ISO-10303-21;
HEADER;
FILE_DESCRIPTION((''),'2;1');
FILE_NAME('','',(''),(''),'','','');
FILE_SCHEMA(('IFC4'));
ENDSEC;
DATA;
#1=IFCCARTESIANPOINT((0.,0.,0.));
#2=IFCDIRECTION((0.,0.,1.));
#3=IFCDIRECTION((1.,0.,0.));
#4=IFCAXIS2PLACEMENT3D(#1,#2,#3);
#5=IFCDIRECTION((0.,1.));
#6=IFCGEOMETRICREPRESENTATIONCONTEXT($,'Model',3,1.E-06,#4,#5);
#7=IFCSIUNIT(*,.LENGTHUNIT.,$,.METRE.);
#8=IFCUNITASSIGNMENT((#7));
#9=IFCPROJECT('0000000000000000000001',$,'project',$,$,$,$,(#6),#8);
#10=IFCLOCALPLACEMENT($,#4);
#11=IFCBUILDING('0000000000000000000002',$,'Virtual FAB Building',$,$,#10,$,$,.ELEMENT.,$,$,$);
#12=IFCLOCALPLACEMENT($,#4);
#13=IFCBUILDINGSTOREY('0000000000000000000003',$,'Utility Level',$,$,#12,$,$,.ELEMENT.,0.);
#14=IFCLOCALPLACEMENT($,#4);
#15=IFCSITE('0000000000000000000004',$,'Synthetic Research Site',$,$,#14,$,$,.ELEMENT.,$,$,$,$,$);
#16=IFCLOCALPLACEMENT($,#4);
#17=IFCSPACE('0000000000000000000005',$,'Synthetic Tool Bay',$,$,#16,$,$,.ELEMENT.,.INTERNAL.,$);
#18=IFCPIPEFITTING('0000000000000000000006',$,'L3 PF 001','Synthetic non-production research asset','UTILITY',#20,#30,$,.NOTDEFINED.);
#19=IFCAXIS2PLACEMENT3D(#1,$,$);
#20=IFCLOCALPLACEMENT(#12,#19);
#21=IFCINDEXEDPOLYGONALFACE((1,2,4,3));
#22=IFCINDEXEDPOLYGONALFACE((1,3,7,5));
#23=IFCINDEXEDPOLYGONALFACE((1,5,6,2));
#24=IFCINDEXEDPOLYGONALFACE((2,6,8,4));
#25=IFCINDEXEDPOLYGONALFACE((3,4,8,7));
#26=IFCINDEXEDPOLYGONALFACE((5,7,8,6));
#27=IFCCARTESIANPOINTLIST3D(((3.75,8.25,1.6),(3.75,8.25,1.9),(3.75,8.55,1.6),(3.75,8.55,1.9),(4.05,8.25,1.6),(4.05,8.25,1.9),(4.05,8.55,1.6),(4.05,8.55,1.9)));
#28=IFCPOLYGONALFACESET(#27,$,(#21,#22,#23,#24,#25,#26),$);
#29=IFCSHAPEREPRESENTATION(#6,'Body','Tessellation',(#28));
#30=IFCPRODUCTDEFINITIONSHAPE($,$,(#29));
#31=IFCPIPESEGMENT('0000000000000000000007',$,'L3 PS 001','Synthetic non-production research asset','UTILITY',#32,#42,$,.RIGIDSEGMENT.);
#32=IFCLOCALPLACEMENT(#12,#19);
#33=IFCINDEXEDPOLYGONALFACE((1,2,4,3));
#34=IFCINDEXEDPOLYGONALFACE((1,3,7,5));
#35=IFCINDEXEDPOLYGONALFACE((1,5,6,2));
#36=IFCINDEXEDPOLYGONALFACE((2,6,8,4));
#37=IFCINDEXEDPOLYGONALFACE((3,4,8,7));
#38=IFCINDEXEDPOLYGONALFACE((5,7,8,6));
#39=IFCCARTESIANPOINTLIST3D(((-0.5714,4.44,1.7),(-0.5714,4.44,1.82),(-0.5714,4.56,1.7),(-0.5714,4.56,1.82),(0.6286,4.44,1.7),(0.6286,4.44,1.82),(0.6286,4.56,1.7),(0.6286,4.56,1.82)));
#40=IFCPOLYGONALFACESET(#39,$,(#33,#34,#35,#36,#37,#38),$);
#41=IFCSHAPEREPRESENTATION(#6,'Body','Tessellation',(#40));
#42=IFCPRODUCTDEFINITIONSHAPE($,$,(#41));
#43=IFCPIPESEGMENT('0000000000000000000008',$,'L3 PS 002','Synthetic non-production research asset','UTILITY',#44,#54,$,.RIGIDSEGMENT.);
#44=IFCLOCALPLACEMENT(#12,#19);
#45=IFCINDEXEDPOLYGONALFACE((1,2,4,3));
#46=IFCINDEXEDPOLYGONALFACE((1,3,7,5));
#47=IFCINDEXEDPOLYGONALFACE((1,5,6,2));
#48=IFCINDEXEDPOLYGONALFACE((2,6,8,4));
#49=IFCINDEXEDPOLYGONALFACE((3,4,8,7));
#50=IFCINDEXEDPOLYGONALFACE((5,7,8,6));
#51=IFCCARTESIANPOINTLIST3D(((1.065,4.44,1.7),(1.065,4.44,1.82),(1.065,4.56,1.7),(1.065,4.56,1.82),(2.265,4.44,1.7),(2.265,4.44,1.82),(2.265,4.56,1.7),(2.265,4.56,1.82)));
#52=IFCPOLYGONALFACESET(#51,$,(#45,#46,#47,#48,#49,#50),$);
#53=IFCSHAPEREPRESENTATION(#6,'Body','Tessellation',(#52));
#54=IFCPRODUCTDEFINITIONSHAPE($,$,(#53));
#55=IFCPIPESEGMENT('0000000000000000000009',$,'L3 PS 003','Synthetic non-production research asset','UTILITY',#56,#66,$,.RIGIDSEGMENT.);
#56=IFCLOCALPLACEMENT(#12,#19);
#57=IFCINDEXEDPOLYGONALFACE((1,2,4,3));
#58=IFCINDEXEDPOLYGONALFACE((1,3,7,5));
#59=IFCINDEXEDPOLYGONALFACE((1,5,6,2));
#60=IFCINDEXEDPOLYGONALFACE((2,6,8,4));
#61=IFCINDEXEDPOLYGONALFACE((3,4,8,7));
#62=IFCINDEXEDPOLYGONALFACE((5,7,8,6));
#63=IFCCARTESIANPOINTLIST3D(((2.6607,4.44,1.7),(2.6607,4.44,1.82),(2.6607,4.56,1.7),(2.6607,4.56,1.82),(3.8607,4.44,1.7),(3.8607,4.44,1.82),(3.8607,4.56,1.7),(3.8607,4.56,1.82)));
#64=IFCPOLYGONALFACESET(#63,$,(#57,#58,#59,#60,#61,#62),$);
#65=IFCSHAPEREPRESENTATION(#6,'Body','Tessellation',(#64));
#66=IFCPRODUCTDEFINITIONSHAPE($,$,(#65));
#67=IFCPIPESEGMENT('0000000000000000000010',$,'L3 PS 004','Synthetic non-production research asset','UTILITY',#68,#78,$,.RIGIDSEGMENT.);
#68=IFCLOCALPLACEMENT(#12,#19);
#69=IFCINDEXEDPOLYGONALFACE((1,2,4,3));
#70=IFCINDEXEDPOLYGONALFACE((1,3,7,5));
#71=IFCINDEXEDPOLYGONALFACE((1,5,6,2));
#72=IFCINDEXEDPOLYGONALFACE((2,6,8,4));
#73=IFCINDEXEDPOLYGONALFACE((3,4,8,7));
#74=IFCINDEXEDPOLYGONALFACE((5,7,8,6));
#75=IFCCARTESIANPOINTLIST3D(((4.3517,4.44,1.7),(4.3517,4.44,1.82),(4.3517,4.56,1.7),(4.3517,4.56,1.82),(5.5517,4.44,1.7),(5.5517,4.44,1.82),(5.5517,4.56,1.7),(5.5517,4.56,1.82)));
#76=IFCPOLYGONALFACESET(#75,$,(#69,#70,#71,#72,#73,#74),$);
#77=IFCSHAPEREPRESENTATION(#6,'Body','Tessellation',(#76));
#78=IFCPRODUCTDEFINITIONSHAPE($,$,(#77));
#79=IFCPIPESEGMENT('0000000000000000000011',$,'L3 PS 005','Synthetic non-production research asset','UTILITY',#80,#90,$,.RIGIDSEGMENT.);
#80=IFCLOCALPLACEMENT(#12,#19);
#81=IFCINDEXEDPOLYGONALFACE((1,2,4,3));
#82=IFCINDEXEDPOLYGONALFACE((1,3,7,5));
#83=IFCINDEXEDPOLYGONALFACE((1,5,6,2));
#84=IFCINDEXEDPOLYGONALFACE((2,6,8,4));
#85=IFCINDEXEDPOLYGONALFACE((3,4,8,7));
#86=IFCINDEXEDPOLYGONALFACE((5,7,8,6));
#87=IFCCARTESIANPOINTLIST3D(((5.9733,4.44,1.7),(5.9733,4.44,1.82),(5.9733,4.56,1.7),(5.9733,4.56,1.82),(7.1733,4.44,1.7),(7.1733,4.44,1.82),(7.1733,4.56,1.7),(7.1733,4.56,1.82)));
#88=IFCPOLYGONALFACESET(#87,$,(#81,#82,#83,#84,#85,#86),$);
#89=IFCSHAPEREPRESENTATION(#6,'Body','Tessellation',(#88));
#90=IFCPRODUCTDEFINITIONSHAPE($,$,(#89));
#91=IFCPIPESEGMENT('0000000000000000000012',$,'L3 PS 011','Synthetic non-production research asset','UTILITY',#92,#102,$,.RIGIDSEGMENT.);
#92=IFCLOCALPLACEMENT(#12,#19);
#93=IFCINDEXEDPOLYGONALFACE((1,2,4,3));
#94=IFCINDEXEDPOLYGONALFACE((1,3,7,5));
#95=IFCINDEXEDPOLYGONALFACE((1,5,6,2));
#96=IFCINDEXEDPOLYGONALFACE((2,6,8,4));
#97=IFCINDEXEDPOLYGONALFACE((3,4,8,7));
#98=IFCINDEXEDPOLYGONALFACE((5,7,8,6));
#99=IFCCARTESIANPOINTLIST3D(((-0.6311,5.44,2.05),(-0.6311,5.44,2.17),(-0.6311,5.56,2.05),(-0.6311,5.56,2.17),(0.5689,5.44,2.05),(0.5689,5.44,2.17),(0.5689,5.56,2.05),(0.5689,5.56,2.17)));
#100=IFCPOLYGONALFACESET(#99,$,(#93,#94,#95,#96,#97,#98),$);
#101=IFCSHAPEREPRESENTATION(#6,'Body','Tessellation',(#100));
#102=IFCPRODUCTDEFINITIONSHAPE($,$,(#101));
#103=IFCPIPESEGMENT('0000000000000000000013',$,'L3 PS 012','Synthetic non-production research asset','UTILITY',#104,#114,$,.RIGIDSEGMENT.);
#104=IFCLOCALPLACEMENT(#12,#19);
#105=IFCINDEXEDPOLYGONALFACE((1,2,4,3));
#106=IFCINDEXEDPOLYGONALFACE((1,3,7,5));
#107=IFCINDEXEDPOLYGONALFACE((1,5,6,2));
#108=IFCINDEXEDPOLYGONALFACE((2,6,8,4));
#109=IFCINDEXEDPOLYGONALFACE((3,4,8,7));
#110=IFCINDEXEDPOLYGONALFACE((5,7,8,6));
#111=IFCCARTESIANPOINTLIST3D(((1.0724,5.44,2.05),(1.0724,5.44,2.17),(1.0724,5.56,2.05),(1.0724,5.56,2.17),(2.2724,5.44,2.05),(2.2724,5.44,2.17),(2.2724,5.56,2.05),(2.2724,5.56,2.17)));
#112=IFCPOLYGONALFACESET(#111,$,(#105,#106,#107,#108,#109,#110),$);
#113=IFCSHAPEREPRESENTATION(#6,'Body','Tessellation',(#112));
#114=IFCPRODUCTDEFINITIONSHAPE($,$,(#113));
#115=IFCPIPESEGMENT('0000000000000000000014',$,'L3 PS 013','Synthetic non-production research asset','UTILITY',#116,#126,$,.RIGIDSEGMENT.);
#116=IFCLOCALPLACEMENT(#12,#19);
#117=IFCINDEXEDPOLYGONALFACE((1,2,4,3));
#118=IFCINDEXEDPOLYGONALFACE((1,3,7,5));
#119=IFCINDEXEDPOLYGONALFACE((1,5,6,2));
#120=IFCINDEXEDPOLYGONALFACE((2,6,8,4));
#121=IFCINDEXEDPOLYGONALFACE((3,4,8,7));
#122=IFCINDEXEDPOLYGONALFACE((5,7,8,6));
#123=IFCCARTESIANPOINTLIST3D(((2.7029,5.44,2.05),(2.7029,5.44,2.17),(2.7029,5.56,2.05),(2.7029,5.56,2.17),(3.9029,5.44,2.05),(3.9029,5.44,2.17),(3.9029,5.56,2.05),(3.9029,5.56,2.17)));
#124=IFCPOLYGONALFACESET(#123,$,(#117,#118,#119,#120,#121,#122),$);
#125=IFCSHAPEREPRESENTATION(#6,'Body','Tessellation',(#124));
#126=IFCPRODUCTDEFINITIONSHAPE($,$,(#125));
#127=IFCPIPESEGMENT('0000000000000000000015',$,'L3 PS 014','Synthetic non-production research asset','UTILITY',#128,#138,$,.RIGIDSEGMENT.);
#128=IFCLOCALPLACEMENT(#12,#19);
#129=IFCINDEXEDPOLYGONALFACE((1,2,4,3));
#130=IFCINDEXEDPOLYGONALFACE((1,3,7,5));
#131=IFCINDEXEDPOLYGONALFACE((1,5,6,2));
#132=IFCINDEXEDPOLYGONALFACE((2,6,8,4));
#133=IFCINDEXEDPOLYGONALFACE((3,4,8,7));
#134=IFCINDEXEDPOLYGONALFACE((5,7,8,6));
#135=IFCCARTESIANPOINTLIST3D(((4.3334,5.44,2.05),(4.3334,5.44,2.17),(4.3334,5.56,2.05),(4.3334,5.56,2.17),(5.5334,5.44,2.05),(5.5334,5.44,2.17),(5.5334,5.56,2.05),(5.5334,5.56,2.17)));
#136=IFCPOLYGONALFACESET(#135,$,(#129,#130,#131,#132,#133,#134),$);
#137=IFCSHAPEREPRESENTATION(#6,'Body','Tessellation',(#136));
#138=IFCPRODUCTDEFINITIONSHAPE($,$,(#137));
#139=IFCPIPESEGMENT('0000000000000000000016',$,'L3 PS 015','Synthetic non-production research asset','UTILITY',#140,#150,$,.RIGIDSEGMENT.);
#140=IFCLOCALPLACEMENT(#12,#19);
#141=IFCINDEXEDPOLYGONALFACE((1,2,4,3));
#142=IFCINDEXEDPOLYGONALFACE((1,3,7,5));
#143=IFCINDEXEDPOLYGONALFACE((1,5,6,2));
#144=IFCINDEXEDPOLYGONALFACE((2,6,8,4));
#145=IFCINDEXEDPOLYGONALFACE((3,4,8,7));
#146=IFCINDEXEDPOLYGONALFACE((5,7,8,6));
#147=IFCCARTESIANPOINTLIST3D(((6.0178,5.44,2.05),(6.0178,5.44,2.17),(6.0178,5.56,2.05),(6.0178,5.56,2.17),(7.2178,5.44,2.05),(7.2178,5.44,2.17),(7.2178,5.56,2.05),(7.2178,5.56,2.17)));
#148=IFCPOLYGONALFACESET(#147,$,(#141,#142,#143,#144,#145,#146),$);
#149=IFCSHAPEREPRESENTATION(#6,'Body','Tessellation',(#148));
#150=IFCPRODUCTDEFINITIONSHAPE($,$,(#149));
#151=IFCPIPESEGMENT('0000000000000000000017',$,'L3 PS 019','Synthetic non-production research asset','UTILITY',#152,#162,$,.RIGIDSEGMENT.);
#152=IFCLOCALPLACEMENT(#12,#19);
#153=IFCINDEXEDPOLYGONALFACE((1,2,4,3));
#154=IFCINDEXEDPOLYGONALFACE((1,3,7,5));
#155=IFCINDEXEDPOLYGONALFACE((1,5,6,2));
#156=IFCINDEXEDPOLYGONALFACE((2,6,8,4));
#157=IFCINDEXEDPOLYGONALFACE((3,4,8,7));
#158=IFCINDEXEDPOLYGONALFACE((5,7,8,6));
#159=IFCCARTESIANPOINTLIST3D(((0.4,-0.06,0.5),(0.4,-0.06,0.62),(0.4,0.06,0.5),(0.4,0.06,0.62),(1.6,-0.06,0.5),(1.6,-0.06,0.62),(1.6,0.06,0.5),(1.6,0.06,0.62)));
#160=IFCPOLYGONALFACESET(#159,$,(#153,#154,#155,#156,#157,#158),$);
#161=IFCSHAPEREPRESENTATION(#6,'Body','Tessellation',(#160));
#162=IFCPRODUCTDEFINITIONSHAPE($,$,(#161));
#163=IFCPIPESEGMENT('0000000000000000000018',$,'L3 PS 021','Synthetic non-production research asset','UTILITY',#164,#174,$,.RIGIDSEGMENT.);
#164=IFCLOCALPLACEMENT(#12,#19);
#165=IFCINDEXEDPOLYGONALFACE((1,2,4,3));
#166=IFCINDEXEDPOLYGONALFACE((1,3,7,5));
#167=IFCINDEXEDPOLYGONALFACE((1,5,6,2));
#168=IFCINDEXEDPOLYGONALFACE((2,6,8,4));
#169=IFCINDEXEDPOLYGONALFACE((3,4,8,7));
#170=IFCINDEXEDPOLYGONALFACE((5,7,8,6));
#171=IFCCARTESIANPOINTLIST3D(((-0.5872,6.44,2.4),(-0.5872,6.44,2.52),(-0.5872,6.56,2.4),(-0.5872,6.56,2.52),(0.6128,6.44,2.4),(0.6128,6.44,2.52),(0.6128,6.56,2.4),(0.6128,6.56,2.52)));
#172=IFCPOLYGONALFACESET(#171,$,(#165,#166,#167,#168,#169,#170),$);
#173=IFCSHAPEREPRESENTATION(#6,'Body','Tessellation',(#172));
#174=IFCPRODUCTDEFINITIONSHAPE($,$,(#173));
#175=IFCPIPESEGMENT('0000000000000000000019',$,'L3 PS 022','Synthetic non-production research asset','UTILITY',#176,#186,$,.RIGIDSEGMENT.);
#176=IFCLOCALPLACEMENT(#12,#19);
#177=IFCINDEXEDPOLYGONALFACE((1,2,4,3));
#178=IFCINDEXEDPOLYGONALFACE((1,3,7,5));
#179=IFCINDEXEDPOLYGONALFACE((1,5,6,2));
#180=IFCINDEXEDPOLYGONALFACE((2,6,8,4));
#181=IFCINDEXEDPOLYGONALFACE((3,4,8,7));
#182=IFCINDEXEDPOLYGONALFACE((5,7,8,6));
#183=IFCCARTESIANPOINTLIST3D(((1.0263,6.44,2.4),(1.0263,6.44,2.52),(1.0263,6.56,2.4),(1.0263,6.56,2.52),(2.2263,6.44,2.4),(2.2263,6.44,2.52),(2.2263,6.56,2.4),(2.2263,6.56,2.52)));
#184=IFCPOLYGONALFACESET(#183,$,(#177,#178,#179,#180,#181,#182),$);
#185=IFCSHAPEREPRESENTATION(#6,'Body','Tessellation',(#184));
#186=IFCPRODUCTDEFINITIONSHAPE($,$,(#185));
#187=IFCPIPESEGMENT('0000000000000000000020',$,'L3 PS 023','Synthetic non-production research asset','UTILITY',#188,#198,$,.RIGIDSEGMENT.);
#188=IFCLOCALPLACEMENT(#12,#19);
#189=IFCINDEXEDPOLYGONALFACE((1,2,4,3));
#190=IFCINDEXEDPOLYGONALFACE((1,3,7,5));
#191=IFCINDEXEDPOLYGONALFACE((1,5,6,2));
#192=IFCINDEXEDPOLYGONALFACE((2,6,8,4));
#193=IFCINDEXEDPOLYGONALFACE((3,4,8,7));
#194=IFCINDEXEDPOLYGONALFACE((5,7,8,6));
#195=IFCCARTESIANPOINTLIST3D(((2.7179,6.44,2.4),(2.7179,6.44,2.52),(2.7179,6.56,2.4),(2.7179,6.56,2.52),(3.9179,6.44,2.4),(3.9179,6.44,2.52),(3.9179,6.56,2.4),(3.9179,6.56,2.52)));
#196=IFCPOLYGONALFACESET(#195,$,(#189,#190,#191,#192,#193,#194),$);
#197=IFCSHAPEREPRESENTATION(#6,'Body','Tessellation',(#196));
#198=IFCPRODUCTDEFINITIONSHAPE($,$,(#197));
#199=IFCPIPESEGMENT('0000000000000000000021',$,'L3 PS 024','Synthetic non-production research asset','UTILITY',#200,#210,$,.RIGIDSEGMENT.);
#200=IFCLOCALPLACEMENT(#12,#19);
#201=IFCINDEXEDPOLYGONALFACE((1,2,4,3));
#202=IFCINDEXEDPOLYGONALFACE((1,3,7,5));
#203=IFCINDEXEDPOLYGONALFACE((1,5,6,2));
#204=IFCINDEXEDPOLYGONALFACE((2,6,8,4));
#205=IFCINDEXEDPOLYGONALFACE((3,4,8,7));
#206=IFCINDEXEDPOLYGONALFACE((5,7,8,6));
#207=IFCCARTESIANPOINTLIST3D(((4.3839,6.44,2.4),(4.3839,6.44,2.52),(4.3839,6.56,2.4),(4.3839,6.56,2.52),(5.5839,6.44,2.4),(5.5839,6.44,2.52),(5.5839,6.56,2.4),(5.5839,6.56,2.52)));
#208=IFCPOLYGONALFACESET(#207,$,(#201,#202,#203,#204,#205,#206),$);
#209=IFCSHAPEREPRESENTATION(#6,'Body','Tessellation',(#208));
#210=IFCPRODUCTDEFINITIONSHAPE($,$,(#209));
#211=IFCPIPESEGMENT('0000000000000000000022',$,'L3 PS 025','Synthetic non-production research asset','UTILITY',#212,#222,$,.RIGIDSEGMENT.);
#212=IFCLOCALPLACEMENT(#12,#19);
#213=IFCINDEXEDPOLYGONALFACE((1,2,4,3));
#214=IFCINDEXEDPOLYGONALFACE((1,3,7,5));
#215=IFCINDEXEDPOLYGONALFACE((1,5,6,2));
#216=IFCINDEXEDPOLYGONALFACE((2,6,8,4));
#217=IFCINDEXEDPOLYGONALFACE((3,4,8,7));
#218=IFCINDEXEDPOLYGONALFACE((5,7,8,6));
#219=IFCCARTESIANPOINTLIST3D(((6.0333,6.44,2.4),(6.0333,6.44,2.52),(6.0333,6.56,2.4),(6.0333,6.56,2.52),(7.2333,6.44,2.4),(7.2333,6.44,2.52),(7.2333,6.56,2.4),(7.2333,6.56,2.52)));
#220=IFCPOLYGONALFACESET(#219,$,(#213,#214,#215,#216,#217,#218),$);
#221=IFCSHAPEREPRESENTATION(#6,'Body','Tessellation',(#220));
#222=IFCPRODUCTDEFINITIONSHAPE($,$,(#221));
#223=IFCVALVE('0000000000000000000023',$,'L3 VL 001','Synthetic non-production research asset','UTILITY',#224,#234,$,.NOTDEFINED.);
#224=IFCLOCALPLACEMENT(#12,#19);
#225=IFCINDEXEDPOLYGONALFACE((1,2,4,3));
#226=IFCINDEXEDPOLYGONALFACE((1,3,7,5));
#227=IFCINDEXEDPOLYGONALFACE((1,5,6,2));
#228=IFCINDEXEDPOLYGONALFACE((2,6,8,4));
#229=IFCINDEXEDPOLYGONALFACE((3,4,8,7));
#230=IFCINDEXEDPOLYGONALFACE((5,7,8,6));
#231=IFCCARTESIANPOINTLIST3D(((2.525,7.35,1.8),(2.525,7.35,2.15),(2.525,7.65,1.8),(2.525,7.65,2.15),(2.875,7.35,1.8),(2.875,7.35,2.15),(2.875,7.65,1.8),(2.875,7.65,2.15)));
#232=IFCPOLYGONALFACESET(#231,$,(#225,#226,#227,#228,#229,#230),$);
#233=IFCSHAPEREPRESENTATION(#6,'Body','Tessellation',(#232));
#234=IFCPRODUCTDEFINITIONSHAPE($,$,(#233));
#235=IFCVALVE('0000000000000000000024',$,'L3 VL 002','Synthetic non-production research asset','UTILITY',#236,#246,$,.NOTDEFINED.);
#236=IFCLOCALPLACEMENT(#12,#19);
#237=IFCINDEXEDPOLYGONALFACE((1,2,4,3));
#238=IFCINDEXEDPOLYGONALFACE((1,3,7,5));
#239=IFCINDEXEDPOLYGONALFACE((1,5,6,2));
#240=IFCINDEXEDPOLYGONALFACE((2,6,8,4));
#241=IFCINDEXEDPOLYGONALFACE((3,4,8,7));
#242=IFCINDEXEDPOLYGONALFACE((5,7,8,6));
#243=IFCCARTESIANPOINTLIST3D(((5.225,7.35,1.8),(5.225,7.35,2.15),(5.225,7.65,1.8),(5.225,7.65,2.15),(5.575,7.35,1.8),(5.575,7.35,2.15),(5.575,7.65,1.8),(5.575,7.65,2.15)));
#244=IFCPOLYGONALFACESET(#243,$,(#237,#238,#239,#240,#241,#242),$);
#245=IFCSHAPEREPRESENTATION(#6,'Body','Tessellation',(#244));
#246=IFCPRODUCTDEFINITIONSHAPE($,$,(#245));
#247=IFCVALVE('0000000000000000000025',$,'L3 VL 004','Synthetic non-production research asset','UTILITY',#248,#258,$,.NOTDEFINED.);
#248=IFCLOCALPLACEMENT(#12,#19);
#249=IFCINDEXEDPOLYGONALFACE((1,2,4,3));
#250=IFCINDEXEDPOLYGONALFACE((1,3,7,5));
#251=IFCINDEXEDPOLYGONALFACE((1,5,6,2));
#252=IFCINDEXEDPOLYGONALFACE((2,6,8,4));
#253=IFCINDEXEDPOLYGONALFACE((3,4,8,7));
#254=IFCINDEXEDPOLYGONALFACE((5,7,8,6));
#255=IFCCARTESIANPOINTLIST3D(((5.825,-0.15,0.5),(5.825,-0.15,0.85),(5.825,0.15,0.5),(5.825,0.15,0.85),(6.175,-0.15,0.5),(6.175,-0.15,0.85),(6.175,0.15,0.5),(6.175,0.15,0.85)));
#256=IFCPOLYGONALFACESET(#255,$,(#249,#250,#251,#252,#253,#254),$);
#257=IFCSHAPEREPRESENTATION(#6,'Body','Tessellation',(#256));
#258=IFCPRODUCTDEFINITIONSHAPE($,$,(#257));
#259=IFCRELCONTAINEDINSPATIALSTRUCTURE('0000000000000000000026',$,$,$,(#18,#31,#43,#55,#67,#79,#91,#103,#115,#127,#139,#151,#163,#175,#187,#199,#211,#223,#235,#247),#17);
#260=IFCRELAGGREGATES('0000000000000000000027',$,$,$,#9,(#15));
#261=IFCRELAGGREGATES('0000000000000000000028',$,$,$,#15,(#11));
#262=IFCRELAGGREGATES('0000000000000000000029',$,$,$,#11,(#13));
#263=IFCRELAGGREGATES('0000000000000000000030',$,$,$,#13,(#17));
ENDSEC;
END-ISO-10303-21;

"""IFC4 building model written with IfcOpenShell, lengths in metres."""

from ifc_helpers import new_model, si_unit, direction, frame, origin_with_axes, origin_2d_with_axis, place, context, project, spatial, rectangle, extrude, element, save


model = new_model("IFC4")

# Units and contexts
model_context = context("Model", 3, precision=1e-06, world=origin_with_axes(), true_north=direction((0.0, 1.0)))
ifc_project = project(units=[si_unit("LENGTHUNIT", "METRE")], contexts=[model_context])

# Site, building, storey, space
site_placement = place(None, origin_with_axes())
site = spatial("IfcSite", under=ifc_project, at=site_placement, Name="Synthetic Research Site", CompositionType="ELEMENT")
building_placement = place(None, origin_with_axes())
building = spatial("IfcBuilding", under=site, at=building_placement, Name="Virtual FAB Building", CompositionType="ELEMENT")
storey_placement = place(None, origin_with_axes())
storey = spatial("IfcBuildingStorey", under=building, at=storey_placement, Name="Utility Level", CompositionType="ELEMENT", Elevation=0.0)
space_placement = place(None, origin_with_axes())
space = spatial("IfcSpace", under=storey, at=space_placement, Name="Synthetic Tool Bay", CompositionType="ELEMENT", PredefinedType="INTERNAL")

# Pipe fitting
pipe_fitting_placement = place(None, frame((3.9, 8.4, 1.6), z_axis=(0.0, 0.0, 1.0), x_axis=(1.0, 0.0, 0.0)))
element("IfcPipeFitting", 1, at=pipe_fitting_placement, inside=space, Name="L3 PF 001", Description="Synthetic non-production research asset", ObjectType="UTILITY", PredefinedType="NOTDEFINED", context=model_context, shape_type="SweptSolid", body=[
    extrude(rectangle(XDim=0.3, YDim=0.3, at=origin_2d_with_axis()), origin_with_axes(), (0.0, 0.0, 1.0), 0.3),
])

# Pipe segments
for number, where, z_axis, x_axis, name in (
    (2, (0.0286, 4.5, 1.7), (0.0, 0.0, 1.0), (1.0, 0.0, 0.0), "L3 PS 001"),
    (3, (1.665, 4.5, 1.7), (0.0, 0.0, 1.0), (1.0, 0.0, 0.0), "L3 PS 002"),
    (4, (3.2607, 4.5, 1.7), (0.0, 0.0, 1.0), (1.0, 0.0, 0.0), "L3 PS 003"),
    (5, (4.9517, 4.5, 1.7), (0.0, 0.0, 1.0), (1.0, 0.0, 0.0), "L3 PS 004"),
    (6, (6.5733, 4.5, 1.7), (0.0, 0.0, 1.0), (1.0, 0.0, 0.0), "L3 PS 005"),
    (7, (-0.0311, 5.5, 2.05), (0.0, 0.0, 1.0), (1.0, 0.0, 0.0), "L3 PS 011"),
    (8, (1.6724, 5.5, 2.05), (0.0, 0.0, 1.0), (1.0, 0.0, 0.0), "L3 PS 012"),
    (9, (3.3029, 5.5, 2.05), (0.0, 0.0, 1.0), (1.0, 0.0, 0.0), "L3 PS 013"),
    (10, (4.9334, 5.5, 2.05), (0.0, 0.0, 1.0), (1.0, 0.0, 0.0), "L3 PS 014"),
    (11, (6.6178, 5.5, 2.05), (0.0, 0.0, 1.0), (1.0, 0.0, 0.0), "L3 PS 015"),
    (12, (1.0, 0.0, 0.5), (0.0, 0.0, 1.0), (1.0, 0.0, 0.0), "L3 PS 019"),
    (13, (0.0128, 6.5, 2.4), (0.0, 0.0, 1.0), (1.0, 0.0, 0.0), "L3 PS 021"),
    (14, (1.6263, 6.5, 2.4), (0.0, 0.0, 1.0), (1.0, 0.0, 0.0), "L3 PS 022"),
    (15, (3.3179, 6.5, 2.4), (0.0, 0.0, 1.0), (1.0, 0.0, 0.0), "L3 PS 023"),
    (16, (4.9839, 6.5, 2.4), (0.0, 0.0, 1.0), (1.0, 0.0, 0.0), "L3 PS 024"),
    (17, (6.6333, 6.5, 2.4), (0.0, 0.0, 1.0), (1.0, 0.0, 0.0), "L3 PS 025"),
):
    element("IfcPipeSegment", number, at=place(None, frame(where, z_axis=z_axis, x_axis=x_axis)), inside=space, Name=name, Description="Synthetic non-production research asset", ObjectType="UTILITY", PredefinedType="RIGIDSEGMENT", context=model_context, shape_type="SweptSolid", body=[
        extrude(rectangle(XDim=1.2, YDim=0.12, at=origin_2d_with_axis()), origin_with_axes(), (0.0, 0.0, 1.0), 0.12),
    ])

# Valves
for number, where, z_axis, x_axis, name in (
    (18, (2.7, 7.5, 1.8), (0.0, 0.0, 1.0), (1.0, 0.0, 0.0), "L3 VL 001"),
    (19, (5.4, 7.5, 1.8), (0.0, 0.0, 1.0), (1.0, 0.0, 0.0), "L3 VL 002"),
    (20, (6.0, 0.0, 0.5), (0.0, 0.0, 1.0), (1.0, 0.0, 0.0), "L3 VL 004"),
):
    element("IfcValve", number, at=place(None, frame(where, z_axis=z_axis, x_axis=x_axis)), inside=space, Name=name, Description="Synthetic non-production research asset", ObjectType="UTILITY", PredefinedType="NOTDEFINED", context=model_context, shape_type="SweptSolid", body=[
        extrude(rectangle(XDim=0.35, YDim=0.3, at=origin_2d_with_axis()), origin_with_axes(), (0.0, 0.0, 1.0), 0.35),
    ])

save(model, "model.ifc")
